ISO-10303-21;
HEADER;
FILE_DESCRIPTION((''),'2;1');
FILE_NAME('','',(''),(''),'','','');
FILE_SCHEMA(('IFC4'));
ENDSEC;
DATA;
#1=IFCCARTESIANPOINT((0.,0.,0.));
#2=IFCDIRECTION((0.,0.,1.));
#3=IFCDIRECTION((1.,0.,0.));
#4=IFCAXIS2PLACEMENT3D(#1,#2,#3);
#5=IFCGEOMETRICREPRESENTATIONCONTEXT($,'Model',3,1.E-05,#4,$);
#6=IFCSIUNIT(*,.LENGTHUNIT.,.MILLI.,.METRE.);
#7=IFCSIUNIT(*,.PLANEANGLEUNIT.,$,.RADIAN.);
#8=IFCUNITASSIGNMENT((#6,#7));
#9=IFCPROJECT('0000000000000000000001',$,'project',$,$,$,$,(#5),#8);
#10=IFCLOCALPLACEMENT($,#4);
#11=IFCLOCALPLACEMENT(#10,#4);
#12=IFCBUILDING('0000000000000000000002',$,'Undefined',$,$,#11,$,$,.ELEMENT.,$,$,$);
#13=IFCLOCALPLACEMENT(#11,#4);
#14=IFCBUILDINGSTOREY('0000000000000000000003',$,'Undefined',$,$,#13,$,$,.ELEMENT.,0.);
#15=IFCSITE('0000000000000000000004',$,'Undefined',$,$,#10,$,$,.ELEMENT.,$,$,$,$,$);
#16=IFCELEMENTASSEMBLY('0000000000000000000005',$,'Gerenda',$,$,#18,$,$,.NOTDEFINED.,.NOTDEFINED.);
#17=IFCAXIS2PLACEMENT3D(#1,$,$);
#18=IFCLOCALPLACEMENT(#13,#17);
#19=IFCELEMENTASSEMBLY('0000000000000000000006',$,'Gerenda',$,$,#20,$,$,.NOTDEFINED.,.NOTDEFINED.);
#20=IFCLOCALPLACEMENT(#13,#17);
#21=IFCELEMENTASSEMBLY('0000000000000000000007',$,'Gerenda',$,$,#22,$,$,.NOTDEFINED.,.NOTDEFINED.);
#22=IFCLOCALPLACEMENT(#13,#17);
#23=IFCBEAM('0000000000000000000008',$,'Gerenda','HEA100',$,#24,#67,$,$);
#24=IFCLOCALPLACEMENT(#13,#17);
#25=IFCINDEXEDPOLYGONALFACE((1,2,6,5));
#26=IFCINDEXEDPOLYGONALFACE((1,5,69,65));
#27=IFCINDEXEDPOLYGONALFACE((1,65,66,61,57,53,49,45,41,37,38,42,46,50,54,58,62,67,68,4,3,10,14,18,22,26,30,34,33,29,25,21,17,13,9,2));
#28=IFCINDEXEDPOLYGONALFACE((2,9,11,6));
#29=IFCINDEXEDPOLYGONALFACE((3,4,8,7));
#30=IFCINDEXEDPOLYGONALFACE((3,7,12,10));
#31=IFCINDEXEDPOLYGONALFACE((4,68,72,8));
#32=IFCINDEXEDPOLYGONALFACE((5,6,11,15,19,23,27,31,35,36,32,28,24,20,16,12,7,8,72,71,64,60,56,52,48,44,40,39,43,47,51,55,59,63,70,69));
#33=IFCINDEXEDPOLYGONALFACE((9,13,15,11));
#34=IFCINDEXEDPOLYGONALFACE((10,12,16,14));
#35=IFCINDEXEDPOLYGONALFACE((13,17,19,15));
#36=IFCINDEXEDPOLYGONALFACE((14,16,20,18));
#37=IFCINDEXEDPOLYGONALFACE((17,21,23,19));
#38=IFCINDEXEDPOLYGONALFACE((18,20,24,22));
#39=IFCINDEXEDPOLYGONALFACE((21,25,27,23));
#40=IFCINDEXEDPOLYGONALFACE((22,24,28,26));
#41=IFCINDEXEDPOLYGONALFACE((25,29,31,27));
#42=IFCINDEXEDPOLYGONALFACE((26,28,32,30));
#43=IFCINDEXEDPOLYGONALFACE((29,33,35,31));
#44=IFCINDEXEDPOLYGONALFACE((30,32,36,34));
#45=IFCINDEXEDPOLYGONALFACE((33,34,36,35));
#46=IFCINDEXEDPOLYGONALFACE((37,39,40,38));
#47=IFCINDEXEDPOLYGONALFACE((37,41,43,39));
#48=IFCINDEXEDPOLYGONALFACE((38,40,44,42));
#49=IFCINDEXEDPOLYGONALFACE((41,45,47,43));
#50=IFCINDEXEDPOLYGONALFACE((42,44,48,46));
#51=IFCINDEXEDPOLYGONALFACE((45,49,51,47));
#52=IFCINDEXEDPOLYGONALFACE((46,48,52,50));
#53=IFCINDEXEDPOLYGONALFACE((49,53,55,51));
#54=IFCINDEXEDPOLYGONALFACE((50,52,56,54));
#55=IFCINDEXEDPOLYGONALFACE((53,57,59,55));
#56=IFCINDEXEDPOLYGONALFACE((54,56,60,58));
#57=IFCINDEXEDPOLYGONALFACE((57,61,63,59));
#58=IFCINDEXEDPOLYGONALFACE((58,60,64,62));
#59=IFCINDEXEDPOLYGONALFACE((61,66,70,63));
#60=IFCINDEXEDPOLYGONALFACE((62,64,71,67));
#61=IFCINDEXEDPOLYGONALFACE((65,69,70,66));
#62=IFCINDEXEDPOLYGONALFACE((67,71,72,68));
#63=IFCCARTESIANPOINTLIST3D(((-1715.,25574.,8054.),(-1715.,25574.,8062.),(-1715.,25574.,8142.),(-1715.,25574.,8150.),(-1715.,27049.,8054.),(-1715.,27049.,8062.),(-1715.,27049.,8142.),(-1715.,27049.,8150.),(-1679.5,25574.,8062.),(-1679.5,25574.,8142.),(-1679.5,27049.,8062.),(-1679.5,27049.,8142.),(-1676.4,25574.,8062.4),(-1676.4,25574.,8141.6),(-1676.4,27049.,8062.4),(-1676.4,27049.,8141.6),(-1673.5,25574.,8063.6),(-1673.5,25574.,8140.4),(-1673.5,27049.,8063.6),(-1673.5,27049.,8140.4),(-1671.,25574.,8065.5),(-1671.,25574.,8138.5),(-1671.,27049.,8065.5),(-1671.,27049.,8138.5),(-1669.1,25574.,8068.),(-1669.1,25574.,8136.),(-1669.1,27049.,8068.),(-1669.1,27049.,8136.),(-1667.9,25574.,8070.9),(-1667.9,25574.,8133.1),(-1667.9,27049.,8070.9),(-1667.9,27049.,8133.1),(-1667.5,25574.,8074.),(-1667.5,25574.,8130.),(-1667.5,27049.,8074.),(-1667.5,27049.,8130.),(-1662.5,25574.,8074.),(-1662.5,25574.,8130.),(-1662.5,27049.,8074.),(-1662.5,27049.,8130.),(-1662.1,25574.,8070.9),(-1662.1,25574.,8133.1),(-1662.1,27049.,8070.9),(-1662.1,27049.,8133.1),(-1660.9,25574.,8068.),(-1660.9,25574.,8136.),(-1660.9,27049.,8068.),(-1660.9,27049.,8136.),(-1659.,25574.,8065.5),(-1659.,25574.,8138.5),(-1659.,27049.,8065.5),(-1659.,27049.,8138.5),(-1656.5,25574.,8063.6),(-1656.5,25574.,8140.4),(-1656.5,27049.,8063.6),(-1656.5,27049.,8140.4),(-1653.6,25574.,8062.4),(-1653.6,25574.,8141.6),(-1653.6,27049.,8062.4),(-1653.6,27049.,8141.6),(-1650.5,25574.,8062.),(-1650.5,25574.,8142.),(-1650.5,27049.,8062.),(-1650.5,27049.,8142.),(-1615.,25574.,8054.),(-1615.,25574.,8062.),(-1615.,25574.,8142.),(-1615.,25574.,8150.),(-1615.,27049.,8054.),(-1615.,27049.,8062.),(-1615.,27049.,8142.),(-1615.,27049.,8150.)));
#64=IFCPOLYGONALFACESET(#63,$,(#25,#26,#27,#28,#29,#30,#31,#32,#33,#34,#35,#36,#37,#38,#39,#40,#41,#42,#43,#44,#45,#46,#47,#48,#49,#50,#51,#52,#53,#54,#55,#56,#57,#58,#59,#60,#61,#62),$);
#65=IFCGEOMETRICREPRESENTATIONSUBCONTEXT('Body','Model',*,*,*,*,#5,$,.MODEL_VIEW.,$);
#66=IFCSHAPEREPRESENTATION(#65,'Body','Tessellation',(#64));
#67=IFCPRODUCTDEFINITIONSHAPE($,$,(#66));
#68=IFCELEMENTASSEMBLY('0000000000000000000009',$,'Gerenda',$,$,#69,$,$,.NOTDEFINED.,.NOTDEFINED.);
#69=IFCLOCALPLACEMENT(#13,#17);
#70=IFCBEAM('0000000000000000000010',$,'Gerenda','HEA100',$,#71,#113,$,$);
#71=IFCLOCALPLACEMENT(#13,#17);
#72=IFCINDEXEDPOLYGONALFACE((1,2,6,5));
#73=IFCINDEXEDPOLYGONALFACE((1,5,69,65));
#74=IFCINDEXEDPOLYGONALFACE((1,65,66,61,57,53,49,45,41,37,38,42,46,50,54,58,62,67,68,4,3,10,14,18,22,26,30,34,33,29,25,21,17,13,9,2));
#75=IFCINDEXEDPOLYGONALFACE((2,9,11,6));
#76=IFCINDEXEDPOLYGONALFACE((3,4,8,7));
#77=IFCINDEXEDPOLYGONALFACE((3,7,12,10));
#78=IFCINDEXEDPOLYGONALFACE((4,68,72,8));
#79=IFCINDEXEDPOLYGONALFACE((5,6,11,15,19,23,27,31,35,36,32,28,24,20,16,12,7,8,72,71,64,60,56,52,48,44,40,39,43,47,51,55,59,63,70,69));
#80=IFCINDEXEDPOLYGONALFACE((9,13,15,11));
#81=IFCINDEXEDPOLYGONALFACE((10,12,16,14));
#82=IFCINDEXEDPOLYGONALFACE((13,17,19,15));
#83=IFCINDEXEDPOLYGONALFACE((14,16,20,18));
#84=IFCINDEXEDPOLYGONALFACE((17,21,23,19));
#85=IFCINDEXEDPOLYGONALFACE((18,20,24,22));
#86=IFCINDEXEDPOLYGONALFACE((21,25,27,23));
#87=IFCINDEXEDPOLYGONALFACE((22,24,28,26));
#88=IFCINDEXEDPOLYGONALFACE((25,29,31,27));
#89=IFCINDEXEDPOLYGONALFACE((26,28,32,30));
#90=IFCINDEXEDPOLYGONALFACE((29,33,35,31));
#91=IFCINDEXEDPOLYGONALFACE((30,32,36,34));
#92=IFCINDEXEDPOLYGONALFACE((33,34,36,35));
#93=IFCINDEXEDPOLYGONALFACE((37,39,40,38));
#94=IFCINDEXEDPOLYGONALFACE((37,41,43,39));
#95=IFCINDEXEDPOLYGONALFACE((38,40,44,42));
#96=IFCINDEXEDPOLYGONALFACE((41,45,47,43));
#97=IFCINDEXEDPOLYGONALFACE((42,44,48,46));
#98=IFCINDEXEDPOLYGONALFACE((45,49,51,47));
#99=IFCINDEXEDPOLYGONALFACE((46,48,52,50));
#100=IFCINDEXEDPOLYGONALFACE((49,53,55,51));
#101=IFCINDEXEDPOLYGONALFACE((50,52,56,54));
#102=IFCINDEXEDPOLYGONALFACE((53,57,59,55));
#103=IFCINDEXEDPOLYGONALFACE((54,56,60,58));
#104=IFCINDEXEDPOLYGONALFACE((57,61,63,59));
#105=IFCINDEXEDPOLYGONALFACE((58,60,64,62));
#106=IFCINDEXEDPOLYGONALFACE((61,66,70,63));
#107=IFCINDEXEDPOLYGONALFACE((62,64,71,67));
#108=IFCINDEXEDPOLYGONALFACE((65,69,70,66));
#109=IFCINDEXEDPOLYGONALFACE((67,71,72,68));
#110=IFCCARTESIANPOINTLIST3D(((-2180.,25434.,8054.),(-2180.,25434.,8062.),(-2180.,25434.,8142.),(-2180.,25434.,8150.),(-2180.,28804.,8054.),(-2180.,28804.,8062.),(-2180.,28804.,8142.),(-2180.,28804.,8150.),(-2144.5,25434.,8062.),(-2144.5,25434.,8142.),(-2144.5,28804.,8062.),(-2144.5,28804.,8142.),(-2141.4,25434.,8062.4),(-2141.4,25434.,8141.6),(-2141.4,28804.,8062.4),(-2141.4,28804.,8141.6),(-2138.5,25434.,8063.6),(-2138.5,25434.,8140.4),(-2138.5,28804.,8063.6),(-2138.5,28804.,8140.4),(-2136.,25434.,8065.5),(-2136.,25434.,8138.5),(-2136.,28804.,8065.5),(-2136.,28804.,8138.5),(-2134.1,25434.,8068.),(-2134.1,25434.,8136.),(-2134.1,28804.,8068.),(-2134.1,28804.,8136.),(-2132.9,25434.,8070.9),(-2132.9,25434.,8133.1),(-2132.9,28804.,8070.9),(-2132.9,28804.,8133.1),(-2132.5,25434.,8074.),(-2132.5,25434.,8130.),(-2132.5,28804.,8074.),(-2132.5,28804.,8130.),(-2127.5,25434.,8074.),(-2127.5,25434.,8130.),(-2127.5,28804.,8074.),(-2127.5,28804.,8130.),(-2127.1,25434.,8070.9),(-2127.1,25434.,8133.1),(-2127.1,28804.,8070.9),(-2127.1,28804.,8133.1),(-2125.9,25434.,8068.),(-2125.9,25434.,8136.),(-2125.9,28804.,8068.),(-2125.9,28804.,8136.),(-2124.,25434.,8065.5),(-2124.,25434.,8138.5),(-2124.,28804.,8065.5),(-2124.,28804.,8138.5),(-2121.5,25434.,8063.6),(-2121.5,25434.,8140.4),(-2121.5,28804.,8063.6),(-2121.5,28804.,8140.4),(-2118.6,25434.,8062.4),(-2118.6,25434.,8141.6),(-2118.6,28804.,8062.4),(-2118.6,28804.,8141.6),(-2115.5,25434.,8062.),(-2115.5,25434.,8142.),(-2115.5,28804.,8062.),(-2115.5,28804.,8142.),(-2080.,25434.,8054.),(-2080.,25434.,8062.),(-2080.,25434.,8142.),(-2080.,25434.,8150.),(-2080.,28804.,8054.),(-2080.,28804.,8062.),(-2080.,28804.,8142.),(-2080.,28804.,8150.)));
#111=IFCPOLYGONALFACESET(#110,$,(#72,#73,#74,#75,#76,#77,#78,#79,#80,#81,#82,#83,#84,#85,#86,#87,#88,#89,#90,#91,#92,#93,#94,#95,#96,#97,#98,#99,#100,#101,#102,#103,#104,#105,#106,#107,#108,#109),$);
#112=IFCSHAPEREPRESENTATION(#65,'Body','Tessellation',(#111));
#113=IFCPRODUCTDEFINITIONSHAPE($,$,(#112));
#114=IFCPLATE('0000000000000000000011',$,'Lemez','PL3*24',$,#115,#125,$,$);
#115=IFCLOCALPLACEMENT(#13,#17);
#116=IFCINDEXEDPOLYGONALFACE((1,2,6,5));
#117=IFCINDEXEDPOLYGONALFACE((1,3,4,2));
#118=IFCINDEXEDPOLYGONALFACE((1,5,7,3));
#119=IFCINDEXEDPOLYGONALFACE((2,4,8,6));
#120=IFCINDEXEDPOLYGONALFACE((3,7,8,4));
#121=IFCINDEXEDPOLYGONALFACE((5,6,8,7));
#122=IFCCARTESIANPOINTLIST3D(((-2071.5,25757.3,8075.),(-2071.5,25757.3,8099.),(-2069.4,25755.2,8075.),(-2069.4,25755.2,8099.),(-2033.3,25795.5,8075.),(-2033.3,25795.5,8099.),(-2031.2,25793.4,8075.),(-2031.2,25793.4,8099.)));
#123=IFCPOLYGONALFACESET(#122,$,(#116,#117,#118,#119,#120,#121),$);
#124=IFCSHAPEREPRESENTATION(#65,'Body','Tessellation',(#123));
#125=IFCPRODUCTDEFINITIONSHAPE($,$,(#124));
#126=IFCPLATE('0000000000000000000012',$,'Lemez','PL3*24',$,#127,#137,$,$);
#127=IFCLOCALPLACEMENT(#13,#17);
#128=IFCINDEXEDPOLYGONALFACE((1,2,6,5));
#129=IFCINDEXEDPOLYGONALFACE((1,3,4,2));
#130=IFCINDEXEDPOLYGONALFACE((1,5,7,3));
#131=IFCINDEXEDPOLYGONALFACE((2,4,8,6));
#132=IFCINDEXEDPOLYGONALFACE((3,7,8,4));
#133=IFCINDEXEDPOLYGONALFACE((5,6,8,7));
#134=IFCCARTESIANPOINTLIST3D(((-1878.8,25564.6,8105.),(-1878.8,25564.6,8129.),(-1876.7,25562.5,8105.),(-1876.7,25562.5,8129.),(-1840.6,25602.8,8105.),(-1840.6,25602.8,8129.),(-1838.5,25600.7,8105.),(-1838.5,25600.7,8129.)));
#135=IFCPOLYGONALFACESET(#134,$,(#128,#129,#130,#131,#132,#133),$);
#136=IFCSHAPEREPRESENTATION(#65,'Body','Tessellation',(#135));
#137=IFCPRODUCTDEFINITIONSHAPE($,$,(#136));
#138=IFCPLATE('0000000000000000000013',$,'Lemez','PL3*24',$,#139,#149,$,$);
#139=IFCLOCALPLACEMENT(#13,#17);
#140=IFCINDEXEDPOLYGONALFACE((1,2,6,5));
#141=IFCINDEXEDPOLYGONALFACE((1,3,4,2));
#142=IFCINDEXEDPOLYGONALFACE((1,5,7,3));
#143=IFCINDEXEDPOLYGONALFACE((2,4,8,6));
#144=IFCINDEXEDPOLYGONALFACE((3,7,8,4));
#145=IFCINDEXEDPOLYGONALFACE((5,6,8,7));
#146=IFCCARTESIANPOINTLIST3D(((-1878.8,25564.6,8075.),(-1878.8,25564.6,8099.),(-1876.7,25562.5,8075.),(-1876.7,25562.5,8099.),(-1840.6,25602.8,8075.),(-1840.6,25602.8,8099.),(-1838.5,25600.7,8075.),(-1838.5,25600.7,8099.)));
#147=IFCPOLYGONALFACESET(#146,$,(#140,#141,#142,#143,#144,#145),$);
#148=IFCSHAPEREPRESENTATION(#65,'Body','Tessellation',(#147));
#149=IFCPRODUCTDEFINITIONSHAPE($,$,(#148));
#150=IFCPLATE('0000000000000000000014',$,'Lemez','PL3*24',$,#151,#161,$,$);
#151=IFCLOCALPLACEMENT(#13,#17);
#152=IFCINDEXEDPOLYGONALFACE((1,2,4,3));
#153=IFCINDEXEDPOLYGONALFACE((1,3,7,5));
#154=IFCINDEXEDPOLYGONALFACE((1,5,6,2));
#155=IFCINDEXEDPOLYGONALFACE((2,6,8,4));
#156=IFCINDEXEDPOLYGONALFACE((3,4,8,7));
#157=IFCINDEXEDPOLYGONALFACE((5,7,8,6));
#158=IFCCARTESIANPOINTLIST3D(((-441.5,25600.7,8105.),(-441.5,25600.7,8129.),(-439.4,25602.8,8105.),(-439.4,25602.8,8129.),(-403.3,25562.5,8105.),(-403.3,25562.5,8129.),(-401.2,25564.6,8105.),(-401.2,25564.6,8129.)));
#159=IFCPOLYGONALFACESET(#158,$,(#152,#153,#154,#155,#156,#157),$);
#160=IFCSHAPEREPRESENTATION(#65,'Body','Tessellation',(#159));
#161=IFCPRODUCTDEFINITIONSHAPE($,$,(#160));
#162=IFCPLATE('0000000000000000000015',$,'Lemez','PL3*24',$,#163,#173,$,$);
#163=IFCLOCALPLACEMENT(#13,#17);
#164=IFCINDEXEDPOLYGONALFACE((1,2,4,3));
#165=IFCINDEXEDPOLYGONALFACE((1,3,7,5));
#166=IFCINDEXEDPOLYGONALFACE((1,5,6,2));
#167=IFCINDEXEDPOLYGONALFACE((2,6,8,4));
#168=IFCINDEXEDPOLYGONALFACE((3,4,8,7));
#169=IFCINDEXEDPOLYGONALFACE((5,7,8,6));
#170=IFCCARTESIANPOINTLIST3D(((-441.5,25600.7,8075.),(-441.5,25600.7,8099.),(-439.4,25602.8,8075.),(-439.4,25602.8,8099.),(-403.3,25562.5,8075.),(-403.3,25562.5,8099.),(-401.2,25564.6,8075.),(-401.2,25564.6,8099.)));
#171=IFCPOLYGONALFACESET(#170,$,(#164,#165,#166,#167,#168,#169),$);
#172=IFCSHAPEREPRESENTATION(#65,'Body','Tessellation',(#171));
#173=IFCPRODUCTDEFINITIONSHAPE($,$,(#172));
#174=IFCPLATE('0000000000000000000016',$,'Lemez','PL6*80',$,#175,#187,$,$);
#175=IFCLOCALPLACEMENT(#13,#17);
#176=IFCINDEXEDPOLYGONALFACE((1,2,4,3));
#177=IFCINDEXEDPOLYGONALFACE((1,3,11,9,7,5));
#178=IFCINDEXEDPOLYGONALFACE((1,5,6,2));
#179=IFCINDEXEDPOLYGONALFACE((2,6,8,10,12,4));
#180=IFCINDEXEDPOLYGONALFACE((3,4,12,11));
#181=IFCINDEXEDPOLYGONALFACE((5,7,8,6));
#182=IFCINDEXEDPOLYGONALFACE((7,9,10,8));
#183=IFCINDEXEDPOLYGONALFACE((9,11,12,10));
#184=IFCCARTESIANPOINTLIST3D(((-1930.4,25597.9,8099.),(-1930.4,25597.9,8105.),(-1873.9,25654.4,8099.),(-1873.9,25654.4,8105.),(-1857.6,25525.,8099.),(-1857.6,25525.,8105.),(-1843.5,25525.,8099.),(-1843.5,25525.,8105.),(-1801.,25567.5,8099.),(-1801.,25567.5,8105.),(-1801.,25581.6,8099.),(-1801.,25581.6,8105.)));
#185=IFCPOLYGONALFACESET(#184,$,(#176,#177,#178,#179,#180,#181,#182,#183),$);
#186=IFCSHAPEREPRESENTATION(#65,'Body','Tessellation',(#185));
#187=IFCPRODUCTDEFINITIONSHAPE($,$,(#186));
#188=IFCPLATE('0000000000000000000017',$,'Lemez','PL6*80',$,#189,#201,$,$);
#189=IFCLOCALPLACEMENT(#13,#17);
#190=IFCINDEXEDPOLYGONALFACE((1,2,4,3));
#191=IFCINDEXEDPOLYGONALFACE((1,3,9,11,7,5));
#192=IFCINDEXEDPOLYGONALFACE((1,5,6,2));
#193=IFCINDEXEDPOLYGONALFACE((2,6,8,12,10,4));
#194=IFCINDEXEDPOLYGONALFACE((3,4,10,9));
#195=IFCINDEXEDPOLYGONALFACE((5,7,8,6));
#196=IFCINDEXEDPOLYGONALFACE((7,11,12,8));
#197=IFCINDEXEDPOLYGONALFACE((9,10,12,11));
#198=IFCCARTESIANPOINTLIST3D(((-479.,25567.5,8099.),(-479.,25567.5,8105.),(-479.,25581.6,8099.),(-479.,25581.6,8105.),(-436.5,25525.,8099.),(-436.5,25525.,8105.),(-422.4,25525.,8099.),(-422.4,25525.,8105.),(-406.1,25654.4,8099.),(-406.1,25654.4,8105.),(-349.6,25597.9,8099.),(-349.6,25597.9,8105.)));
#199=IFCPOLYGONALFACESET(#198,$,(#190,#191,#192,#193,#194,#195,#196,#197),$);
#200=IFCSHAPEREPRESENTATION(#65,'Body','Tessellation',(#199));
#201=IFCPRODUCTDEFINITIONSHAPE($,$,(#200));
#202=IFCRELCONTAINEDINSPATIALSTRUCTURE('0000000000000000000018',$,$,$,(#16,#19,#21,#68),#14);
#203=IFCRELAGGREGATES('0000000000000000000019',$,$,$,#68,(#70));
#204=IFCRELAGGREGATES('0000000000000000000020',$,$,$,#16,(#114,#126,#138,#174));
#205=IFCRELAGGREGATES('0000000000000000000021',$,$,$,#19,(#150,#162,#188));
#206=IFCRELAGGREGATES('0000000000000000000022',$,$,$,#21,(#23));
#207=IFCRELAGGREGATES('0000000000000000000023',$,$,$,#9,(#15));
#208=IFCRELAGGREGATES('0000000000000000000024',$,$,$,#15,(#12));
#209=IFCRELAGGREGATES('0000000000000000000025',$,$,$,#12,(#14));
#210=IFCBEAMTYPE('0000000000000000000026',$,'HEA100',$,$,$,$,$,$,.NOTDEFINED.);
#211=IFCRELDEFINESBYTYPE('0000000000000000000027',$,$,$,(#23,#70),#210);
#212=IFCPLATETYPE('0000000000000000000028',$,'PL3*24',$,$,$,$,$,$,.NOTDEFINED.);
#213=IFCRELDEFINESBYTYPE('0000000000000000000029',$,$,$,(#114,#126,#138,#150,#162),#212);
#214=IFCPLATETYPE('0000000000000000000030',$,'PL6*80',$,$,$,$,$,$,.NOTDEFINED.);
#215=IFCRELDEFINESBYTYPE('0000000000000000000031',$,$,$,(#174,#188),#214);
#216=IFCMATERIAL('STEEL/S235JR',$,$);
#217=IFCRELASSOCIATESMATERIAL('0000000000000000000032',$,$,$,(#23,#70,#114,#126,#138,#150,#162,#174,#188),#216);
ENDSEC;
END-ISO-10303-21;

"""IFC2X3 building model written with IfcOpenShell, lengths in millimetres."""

from ifc_helpers import new_model, si_unit, frame, origin_with_axes, origin_2d_with_axis, place, context, subcontext, project, spatial, polyline, i_section, outline, extrude, clip, halfspace, material, type_object, element, aggregate, save


model = new_model("IFC2X3")

# Units and contexts
model_context = context("Model", 3, precision=1e-05, world=origin_with_axes())
body_context = subcontext(model_context, "Body", "Model", "MODEL_VIEW")
ifc_project = project(units=[si_unit("LENGTHUNIT", "METRE", prefix="MILLI"), si_unit("PLANEANGLEUNIT", "RADIAN")], contexts=[model_context])

# Site, building, storey
site_placement = place(None, origin_with_axes())
site = spatial("IfcSite", under=ifc_project, at=site_placement, Name="Undefined", CompositionType="ELEMENT")
building_placement = place(site_placement, origin_with_axes())
building = spatial("IfcBuilding", under=site, at=building_placement, Name="Undefined", CompositionType="ELEMENT")
storey_placement = place(building_placement, origin_with_axes())
storey = spatial("IfcBuildingStorey", under=building, at=storey_placement, Name="Undefined", CompositionType="ELEMENT", Elevation=0.0)

# Element assemblies, beams
assembly_1_placement = place(storey_placement, origin_with_axes())
assembly_1 = element("IfcElementAssembly", 1, at=assembly_1_placement, inside=storey, Name="Gerenda", AssemblyPlace="NOTDEFINED", PredefinedType="NOTDEFINED")
ifc_material_1 = material(Name="STEEL/S235JR")
assembly_2_placement = place(storey_placement, origin_with_axes())
assembly_2 = element("IfcElementAssembly", 2, at=assembly_2_placement, inside=storey, Name="Gerenda", AssemblyPlace="NOTDEFINED", PredefinedType="NOTDEFINED")
assembly_3_placement = place(storey_placement, origin_with_axes())
assembly_3 = element("IfcElementAssembly", 3, at=assembly_3_placement, inside=storey, Name="Gerenda", AssemblyPlace="NOTDEFINED", PredefinedType="NOTDEFINED")
beam_type_1 = type_object("IfcBeamType", Name="HEA100", PredefinedType="NOTDEFINED")
beam_1_placement = place(assembly_3_placement, frame((-1665.0, 25504.0, 8102.0), z_axis=(0.0, 0.0, 1.0), x_axis=(0.000003, 1.0, 0.0)))
beam_1 = element("IfcBeam", 4, at=beam_1_placement, type_object=beam_type_1, material=ifc_material_1, Name="Gerenda", Description="HEA100", context=body_context, shape_type="Clipping", body=[
    clip(clip(extrude(i_section(OverallWidth=100.0, OverallDepth=96.0, WebThickness=5.0, FlangeThickness=8.0, FilletRadius=12.0, at=origin_2d_with_axis()), frame((1615.0, 0.0, 0.0), z_axis=(-1.0, 0.0, 0.0), x_axis=(0.0, -1.0, 0.0)), (0.0, 0.0, 1.0), 1615.0), halfspace(frame((1545.0, 0.0, -48.0), z_axis=(-1.0, 0.0, 0.0), x_axis=(0.0, 1.0, 0.0)), True)), halfspace(frame((70.0, 0.0, -48.0), z_axis=(1.0, 0.0, 0.0), x_axis=(0.0, -1.0, 0.0)), True)),
])
assembly_4_placement = place(storey_placement, origin_with_axes())
assembly_4 = element("IfcElementAssembly", 5, at=assembly_4_placement, inside=storey, Name="Gerenda", AssemblyPlace="NOTDEFINED", PredefinedType="NOTDEFINED")
beam_2_placement = place(assembly_4_placement, frame((-2130.0, 25434.0, 8102.0), z_axis=(0.0, 0.0, 1.0), x_axis=(0.000004, 1.0, 0.0)))
beam_2 = element("IfcBeam", 6, at=beam_2_placement, type_object=beam_type_1, material=ifc_material_1, Name="Gerenda", Description="HEA100", context=body_context, shape_type="SweptSolid", body=[
    extrude(i_section(OverallWidth=100.0, OverallDepth=96.0, WebThickness=5.0, FlangeThickness=8.0, FilletRadius=12.0, at=origin_2d_with_axis()), frame((3370.0, 0.0, 0.0), z_axis=(-1.0, 0.0, 0.0), x_axis=(0.0, -1.0, 0.0)), (0.0, 0.0, 1.0), 3370.0),
])

# Plates
plate_type_1 = type_object("IfcPlateType", Name="PL3*24", PredefinedType="NOTDEFINED")
plate_1_placement = place(assembly_1_placement, frame((-2070.4, 25756.2, 8099.0), z_axis=(0.707112, -0.707102, 0.0), x_axis=(0.0, 0.0, -1.0)))
plate_1 = element("IfcPlate", 7, at=plate_1_placement, type_object=plate_type_1, material=ifc_material_1, Name="Lemez", Description="PL3*24", context=body_context, shape_type="SweptSolid", body=[
    extrude(outline(polyline([(0.0, 0.0), (24.0, 0.0), (24.0, 54.0), (0.0, 54.0), (0.0, 0.0)])), frame((0.0, 0.0, -1.5), z_axis=(0.0, 0.0, 1.0), x_axis=(1.0, 0.0, 0.0)), (0.0, 0.0, 1.0), 3.0),
])
plate_2_placement = place(assembly_1_placement, frame((-1839.6, 25601.8, 8129.0), z_axis=(-0.707112, 0.707102, 0.0), x_axis=(0.0, 0.0, -1.0)))
plate_2 = element("IfcPlate", 8, at=plate_2_placement, type_object=plate_type_1, material=ifc_material_1, Name="Lemez", Description="PL3*24", context=body_context, shape_type="SweptSolid", body=[
    extrude(outline(polyline([(0.0, 0.0), (24.0, 0.0), (24.0, 54.0), (0.0, 54.0), (0.0, 0.0)])), frame((0.0, 0.0, -1.5), z_axis=(0.0, 0.0, 1.0), x_axis=(1.0, 0.0, 0.0)), (0.0, 0.0, 1.0), 3.0),
])
plate_3_placement = place(assembly_1_placement, frame((-1839.6, 25601.8, 8099.0), z_axis=(-0.707112, 0.707102, 0.0), x_axis=(0.0, 0.0, -1.0)))
plate_3 = element("IfcPlate", 9, at=plate_3_placement, type_object=plate_type_1, material=ifc_material_1, Name="Lemez", Description="PL3*24", context=body_context, shape_type="SweptSolid", body=[
    extrude(outline(polyline([(0.0, 0.0), (24.0, 0.0), (24.0, 54.0), (0.0, 54.0), (0.0, 0.0)])), frame((0.0, 0.0, -1.5), z_axis=(0.0, 0.0, 1.0), x_axis=(1.0, 0.0, 0.0)), (0.0, 0.0, 1.0), 3.0),
])
plate_4_placement = place(assembly_2_placement, frame((-402.2, 25563.6, 8129.0), z_axis=(0.707112, 0.707102, 0.0), x_axis=(0.0, 0.0, -1.0)))
plate_4 = element("IfcPlate", 10, at=plate_4_placement, type_object=plate_type_1, material=ifc_material_1, Name="Lemez", Description="PL3*24", context=body_context, shape_type="SweptSolid", body=[
    extrude(outline(polyline([(0.0, 0.0), (24.0, 0.0), (24.0, 54.0), (0.0, 54.0), (0.0, 0.0)])), frame((0.0, 0.0, -1.5), z_axis=(0.0, 0.0, 1.0), x_axis=(1.0, 0.0, 0.0)), (0.0, 0.0, 1.0), 3.0),
])
plate_5_placement = place(assembly_2_placement, frame((-402.2, 25563.6, 8099.0), z_axis=(0.707112, 0.707102, 0.0), x_axis=(0.0, 0.0, -1.0)))
plate_5 = element("IfcPlate", 11, at=plate_5_placement, type_object=plate_type_1, material=ifc_material_1, Name="Lemez", Description="PL3*24", context=body_context, shape_type="SweptSolid", body=[
    extrude(outline(polyline([(0.0, 0.0), (24.0, 0.0), (24.0, 54.0), (0.0, 54.0), (0.0, 0.0)])), frame((0.0, 0.0, -1.5), z_axis=(0.0, 0.0, 1.0), x_axis=(1.0, 0.0, 0.0)), (0.0, 0.0, 1.0), 3.0),
])
plate_type_2 = type_object("IfcPlateType", Name="PL6*80", PredefinedType="NOTDEFINED")
plate_6_placement = place(assembly_1_placement, frame((-1857.6, 25525.0, 8102.0), z_axis=(0.0, 0.0, 1.0), x_axis=(1.0, 0.000007, 0.0)))
plate_6 = element("IfcPlate", 12, at=plate_6_placement, type_object=plate_type_2, material=ifc_material_1, Name="Lemez", Description="PL6*80", context=body_context, shape_type="SweptSolid", body=[
    extrude(outline(polyline([(0.0, 0.0), (14.1, 0.0), (56.6, 42.4), (56.6, 56.6), (-16.3, 129.4), (-72.8, 72.8), (0.0, 0.0)])), frame((0.0, 0.0, -3.0), z_axis=(0.0, 0.0, 1.0), x_axis=(1.0, 0.0, 0.0)), (0.0, 0.0, 1.0), 6.0),
])
plate_7_placement = place(assembly_2_placement, frame((-479.0, 25581.6, 8102.0), z_axis=(0.0, 0.0, 1.0), x_axis=(-0.000007, -1.0, 0.0)))
plate_7 = element("IfcPlate", 13, at=plate_7_placement, type_object=plate_type_2, material=ifc_material_1, Name="Lemez", Description="PL6*80", context=body_context, shape_type="SweptSolid", body=[
    extrude(outline(polyline([(0.0, 0.0), (14.1, 0.0), (56.6, 42.4), (56.6, 56.6), (-16.3, 129.4), (-72.8, 72.8), (0.0, 0.0)])), frame((0.0, 0.0, -3.0), z_axis=(0.0, 0.0, 1.0), x_axis=(1.0, 0.0, 0.0)), (0.0, 0.0, 1.0), 6.0),
])
aggregate(assembly_4, [beam_2])

aggregate(assembly_1, [plate_1, plate_2, plate_3, plate_6])
aggregate(assembly_2, [plate_4, plate_5, plate_7])
aggregate(assembly_3, [beam_1])

save(model, "model.ifc")
